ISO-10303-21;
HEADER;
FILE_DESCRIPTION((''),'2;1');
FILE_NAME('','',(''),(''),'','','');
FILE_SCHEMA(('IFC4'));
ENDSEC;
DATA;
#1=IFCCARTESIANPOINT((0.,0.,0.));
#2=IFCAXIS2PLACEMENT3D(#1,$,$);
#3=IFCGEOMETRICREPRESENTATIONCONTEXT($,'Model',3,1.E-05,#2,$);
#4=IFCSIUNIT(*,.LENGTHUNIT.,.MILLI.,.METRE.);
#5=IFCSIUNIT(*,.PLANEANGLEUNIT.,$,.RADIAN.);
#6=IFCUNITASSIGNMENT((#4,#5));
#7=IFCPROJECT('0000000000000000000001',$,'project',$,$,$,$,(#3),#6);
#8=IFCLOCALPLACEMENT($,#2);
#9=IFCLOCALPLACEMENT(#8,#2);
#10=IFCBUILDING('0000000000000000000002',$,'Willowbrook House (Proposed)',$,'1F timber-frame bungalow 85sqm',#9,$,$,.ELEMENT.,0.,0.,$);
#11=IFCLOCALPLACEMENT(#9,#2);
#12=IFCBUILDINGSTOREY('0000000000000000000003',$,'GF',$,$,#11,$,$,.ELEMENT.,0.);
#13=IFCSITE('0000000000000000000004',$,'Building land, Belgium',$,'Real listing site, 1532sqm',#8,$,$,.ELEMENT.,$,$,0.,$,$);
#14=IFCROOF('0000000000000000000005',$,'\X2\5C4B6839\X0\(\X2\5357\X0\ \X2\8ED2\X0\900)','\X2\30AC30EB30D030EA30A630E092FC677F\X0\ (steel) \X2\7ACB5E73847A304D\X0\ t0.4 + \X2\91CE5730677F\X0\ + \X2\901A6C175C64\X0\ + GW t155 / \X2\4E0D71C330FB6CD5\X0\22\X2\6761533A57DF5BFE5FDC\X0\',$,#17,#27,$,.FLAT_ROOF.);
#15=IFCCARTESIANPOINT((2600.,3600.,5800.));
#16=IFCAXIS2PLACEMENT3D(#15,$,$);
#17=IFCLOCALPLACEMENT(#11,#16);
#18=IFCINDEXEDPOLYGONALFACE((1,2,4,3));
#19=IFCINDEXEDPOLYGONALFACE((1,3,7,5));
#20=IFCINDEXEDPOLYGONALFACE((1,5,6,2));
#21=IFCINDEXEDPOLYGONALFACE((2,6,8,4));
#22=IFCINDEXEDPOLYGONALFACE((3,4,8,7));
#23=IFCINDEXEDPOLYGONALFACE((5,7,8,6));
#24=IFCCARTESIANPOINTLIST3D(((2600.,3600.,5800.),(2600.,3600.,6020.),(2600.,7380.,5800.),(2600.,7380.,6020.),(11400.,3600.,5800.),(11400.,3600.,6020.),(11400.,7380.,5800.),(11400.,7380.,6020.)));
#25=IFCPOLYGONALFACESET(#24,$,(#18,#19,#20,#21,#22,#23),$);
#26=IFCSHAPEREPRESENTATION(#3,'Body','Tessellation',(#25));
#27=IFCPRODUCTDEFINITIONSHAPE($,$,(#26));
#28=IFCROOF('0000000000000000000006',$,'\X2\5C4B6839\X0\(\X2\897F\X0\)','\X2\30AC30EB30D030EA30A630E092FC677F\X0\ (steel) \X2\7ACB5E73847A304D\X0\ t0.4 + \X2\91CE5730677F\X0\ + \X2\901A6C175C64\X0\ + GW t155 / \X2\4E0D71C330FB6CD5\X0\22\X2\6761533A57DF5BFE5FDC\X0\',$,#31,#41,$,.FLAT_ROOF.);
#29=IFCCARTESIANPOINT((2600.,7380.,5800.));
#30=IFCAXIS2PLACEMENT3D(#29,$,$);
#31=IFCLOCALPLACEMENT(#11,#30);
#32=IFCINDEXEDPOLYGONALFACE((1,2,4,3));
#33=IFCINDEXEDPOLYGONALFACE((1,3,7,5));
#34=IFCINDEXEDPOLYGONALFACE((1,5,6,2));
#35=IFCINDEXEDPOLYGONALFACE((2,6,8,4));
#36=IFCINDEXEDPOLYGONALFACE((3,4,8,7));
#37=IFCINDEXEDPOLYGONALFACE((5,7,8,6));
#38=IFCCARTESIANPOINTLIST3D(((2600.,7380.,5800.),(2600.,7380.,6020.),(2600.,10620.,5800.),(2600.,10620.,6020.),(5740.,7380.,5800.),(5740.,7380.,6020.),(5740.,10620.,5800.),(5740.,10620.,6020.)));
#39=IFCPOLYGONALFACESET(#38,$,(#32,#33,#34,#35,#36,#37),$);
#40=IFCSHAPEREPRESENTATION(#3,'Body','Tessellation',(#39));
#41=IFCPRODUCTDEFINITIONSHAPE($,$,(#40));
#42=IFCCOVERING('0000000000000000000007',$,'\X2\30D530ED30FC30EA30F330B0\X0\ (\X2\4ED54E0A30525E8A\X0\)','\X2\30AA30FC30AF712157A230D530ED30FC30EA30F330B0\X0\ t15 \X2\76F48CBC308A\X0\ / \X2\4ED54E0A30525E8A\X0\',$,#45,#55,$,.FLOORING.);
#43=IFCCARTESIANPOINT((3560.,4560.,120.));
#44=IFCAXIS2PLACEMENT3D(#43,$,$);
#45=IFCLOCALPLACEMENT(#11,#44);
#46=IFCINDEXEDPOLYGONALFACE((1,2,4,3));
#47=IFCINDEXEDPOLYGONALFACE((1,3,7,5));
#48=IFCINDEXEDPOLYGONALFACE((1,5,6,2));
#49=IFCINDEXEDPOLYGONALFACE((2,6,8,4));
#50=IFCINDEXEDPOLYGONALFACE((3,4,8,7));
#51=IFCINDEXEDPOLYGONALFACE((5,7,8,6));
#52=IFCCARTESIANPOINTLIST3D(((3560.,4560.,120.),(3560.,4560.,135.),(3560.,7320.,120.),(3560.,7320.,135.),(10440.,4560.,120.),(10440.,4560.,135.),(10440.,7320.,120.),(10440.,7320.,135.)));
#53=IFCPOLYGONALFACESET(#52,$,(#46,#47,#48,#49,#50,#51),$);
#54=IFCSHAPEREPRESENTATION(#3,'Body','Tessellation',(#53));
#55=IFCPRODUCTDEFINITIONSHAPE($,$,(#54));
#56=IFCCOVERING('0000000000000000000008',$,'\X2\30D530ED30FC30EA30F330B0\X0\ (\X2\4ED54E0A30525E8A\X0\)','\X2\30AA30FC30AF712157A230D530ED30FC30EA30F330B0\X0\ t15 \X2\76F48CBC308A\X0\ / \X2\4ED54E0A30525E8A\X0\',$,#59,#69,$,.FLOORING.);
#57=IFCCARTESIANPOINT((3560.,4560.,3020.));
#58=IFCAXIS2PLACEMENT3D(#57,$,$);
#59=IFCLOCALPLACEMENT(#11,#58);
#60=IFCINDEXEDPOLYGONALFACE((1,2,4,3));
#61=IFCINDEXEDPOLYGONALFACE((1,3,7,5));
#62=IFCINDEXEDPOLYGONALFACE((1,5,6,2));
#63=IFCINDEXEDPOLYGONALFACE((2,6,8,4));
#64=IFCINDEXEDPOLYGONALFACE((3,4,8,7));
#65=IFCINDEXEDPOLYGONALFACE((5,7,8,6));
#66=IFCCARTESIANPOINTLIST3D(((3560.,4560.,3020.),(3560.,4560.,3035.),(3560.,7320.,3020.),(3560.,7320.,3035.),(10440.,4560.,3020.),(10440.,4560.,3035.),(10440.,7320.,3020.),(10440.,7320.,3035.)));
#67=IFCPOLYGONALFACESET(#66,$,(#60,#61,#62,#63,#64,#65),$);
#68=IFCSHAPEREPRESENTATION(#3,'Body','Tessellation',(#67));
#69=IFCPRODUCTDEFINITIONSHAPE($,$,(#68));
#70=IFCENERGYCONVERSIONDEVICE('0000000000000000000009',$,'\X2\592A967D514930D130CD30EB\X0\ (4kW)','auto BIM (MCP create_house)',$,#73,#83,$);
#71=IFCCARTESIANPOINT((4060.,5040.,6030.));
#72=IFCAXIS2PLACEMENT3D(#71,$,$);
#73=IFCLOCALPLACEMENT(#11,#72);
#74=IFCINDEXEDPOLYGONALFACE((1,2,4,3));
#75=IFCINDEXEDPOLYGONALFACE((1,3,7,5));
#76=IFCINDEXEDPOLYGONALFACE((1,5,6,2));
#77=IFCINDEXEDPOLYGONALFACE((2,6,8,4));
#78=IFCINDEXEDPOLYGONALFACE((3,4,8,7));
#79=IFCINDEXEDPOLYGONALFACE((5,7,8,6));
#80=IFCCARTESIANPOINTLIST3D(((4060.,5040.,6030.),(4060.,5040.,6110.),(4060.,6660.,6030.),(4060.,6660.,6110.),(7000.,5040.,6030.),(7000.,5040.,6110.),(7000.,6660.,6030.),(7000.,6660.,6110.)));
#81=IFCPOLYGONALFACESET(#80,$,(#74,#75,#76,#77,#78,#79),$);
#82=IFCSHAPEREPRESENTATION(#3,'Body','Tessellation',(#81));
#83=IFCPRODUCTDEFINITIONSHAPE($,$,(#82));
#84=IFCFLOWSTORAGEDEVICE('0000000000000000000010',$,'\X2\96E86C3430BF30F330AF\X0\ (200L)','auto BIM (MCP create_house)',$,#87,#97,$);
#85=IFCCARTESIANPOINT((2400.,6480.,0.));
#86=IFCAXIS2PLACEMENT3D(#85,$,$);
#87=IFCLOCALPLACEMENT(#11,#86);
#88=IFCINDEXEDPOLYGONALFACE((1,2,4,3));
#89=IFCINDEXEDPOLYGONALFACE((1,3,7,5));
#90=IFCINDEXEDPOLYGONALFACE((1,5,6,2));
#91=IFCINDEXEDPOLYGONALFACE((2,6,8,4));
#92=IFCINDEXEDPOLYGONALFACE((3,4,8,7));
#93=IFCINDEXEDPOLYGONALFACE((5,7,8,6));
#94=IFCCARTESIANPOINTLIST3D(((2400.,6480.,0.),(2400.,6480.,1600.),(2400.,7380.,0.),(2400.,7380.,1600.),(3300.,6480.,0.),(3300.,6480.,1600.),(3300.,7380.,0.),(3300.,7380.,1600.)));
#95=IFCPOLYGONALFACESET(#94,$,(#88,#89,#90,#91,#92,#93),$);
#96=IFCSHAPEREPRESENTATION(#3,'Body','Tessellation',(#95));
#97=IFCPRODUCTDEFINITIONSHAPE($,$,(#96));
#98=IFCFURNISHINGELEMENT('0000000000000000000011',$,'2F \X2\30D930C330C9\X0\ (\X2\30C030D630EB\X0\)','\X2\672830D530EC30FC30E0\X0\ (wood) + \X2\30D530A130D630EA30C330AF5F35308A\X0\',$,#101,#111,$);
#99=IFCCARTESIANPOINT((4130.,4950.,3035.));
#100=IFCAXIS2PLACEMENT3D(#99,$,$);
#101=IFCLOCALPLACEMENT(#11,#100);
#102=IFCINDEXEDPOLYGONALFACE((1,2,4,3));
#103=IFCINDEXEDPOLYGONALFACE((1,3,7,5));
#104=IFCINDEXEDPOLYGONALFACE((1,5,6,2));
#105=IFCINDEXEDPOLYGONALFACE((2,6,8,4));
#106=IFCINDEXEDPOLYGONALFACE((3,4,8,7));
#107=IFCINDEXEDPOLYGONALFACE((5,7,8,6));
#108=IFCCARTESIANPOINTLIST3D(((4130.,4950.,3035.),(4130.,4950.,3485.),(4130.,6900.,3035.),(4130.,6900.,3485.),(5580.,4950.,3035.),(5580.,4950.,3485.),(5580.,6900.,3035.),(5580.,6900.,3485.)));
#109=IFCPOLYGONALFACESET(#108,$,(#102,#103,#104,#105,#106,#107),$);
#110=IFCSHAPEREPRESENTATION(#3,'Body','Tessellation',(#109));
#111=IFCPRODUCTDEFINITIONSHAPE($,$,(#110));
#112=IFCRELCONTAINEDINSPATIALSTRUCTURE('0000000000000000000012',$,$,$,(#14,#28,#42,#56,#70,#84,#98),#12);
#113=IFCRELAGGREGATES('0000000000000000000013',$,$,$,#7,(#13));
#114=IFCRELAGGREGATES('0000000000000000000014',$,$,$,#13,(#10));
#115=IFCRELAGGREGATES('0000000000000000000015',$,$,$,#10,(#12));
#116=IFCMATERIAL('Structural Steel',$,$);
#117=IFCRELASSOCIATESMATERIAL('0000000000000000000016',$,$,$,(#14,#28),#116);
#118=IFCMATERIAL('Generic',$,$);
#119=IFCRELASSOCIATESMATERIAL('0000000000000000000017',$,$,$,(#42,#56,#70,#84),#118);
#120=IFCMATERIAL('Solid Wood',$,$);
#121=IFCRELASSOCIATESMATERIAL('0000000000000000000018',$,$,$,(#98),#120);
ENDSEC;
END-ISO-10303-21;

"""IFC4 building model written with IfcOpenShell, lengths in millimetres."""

from ifc_helpers import new_model, si_unit, frame, frame_2d, origin, place, context, project, spatial, rectangle, extrude, material, element, save


model = new_model("IFC4")

# Units and contexts
model_context = context("Model", 3, precision=1e-05, world=origin())
ifc_project = project(units=[si_unit("LENGTHUNIT", "METRE", prefix="MILLI"), si_unit("PLANEANGLEUNIT", "RADIAN")], contexts=[model_context])

# Site, building, storey
site_placement = place(None, origin())
site = spatial("IfcSite", under=ifc_project, at=site_placement, Name="Building land, Belgium", ObjectType="Real listing site, 1532sqm", CompositionType="ELEMENT", RefElevation=0.0)
building_placement = place(site_placement, origin())
building = spatial("IfcBuilding", under=site, at=building_placement, Name="Willowbrook House (Proposed)", ObjectType="1F timber-frame bungalow 85sqm", CompositionType="ELEMENT", ElevationOfRefHeight=0.0, ElevationOfTerrain=0.0)
storey_placement = place(building_placement, origin())
storey = spatial("IfcBuildingStorey", under=building, at=storey_placement, Name="GF", CompositionType="ELEMENT", Elevation=0.0)

# Shared definitions
ifc_material_1 = material(Name="Solid Wood")
ifc_material_2 = material(Name="Generic")

# Roofs
ifc_material_3 = material(Name="Structural Steel")
roof_1_placement = place(storey_placement, frame((2600.0, 3600.0, 5800.0)))
element("IfcRoof", 1, at=roof_1_placement, inside=storey, material=ifc_material_3, Name="屋根(南 軒900)", Description="ガルバリウム鋼板 (steel) 立平葺き t0.4 + 野地板 + 通気層 + GW t155 / 不燃・法22条区域対応", PredefinedType="FLAT_ROOF", context=model_context, shape_type="SweptSolid", body=[
    extrude(rectangle(XDim=8800.0, YDim=3780.0, at=frame_2d((4400.0, 1890.0))), frame((2600.0, 3600.0, 5800.0)), (0.0, 0.0, 1.0), 220.0),
])
roof_2_placement = place(storey_placement, frame((2600.0, 7380.0, 5800.0)))
element("IfcRoof", 2, at=roof_2_placement, inside=storey, material=ifc_material_3, Name="屋根(西)", Description="ガルバリウム鋼板 (steel) 立平葺き t0.4 + 野地板 + 通気層 + GW t155 / 不燃・法22条区域対応", PredefinedType="FLAT_ROOF", context=model_context, shape_type="SweptSolid", body=[
    extrude(rectangle(XDim=3140.0, YDim=3240.0, at=frame_2d((1570.0, 1620.0))), frame((2600.0, 7380.0, 5800.0)), (0.0, 0.0, 1.0), 220.0),
])

# Coverings
covering_1_placement = place(storey_placement, frame((3560.0, 4560.0, 120.0)))
element("IfcCovering", 3, at=covering_1_placement, inside=storey, material=ifc_material_2, Name="フローリング (仕上げ床)", Description="オーク無垢フローリング t15 直貼り / 仕上げ床", PredefinedType="FLOORING", context=model_context, shape_type="SweptSolid", body=[
    extrude(rectangle(XDim=6880.0, YDim=2760.0, at=frame_2d((3440.0, 1380.0))), frame((3560.0, 4560.0, 120.0)), (0.0, 0.0, 1.0), 15.0),
])
covering_2_placement = place(storey_placement, frame((3560.0, 4560.0, 3020.0)))
element("IfcCovering", 4, at=covering_2_placement, inside=storey, material=ifc_material_2, Name="フローリング (仕上げ床)", Description="オーク無垢フローリング t15 直貼り / 仕上げ床", PredefinedType="FLOORING", context=model_context, shape_type="SweptSolid", body=[
    extrude(rectangle(XDim=6880.0, YDim=2760.0, at=frame_2d((3440.0, 1380.0))), frame((3560.0, 4560.0, 3020.0)), (0.0, 0.0, 1.0), 15.0),
])

# Energy conversion device
energy_conversion_device_placement = place(storey_placement, frame((4060.0, 5040.0, 6030.0)))
element("IfcEnergyConversionDevice", 5, at=energy_conversion_device_placement, inside=storey, material=ifc_material_2, Name="太陽光パネル (4kW)", Description="auto BIM (MCP create_house)", context=model_context, shape_type="SweptSolid", body=[
    extrude(rectangle(XDim=2940.0, YDim=1620.0, at=frame_2d((1470.0, 810.0))), frame((4060.0, 5040.0, 6030.0)), (0.0, 0.0, 1.0), 80.0),
])

# Flow storage device
flow_storage_device_placement = place(storey_placement, frame((2400.0, 6480.0, 0.0)))
element("IfcFlowStorageDevice", 6, at=flow_storage_device_placement, inside=storey, material=ifc_material_2, Name="雨水タンク (200L)", Description="auto BIM (MCP create_house)", context=model_context, shape_type="SweptSolid", body=[
    extrude(rectangle(XDim=900.0, YDim=900.0, at=frame_2d((450.0, 450.0))), frame((2400.0, 6480.0, 0.0)), (0.0, 0.0, 1.0), 1600.0),
])

# Furnishing element
furnishing_placement = place(storey_placement, frame((4130.0, 4950.0, 3035.0)))
element("IfcFurnishingElement", 7, at=furnishing_placement, inside=storey, material=ifc_material_1, Name="2F ベッド (ダブル)", Description="木フレーム (wood) + ファブリック張り", context=model_context, shape_type="SweptSolid", body=[
    extrude(rectangle(XDim=1450.0, YDim=1950.0, at=frame_2d((725.0, 975.0))), frame((4130.0, 4950.0, 3035.0)), (0.0, 0.0, 1.0), 450.0),
])

save(model, "model.ifc")
